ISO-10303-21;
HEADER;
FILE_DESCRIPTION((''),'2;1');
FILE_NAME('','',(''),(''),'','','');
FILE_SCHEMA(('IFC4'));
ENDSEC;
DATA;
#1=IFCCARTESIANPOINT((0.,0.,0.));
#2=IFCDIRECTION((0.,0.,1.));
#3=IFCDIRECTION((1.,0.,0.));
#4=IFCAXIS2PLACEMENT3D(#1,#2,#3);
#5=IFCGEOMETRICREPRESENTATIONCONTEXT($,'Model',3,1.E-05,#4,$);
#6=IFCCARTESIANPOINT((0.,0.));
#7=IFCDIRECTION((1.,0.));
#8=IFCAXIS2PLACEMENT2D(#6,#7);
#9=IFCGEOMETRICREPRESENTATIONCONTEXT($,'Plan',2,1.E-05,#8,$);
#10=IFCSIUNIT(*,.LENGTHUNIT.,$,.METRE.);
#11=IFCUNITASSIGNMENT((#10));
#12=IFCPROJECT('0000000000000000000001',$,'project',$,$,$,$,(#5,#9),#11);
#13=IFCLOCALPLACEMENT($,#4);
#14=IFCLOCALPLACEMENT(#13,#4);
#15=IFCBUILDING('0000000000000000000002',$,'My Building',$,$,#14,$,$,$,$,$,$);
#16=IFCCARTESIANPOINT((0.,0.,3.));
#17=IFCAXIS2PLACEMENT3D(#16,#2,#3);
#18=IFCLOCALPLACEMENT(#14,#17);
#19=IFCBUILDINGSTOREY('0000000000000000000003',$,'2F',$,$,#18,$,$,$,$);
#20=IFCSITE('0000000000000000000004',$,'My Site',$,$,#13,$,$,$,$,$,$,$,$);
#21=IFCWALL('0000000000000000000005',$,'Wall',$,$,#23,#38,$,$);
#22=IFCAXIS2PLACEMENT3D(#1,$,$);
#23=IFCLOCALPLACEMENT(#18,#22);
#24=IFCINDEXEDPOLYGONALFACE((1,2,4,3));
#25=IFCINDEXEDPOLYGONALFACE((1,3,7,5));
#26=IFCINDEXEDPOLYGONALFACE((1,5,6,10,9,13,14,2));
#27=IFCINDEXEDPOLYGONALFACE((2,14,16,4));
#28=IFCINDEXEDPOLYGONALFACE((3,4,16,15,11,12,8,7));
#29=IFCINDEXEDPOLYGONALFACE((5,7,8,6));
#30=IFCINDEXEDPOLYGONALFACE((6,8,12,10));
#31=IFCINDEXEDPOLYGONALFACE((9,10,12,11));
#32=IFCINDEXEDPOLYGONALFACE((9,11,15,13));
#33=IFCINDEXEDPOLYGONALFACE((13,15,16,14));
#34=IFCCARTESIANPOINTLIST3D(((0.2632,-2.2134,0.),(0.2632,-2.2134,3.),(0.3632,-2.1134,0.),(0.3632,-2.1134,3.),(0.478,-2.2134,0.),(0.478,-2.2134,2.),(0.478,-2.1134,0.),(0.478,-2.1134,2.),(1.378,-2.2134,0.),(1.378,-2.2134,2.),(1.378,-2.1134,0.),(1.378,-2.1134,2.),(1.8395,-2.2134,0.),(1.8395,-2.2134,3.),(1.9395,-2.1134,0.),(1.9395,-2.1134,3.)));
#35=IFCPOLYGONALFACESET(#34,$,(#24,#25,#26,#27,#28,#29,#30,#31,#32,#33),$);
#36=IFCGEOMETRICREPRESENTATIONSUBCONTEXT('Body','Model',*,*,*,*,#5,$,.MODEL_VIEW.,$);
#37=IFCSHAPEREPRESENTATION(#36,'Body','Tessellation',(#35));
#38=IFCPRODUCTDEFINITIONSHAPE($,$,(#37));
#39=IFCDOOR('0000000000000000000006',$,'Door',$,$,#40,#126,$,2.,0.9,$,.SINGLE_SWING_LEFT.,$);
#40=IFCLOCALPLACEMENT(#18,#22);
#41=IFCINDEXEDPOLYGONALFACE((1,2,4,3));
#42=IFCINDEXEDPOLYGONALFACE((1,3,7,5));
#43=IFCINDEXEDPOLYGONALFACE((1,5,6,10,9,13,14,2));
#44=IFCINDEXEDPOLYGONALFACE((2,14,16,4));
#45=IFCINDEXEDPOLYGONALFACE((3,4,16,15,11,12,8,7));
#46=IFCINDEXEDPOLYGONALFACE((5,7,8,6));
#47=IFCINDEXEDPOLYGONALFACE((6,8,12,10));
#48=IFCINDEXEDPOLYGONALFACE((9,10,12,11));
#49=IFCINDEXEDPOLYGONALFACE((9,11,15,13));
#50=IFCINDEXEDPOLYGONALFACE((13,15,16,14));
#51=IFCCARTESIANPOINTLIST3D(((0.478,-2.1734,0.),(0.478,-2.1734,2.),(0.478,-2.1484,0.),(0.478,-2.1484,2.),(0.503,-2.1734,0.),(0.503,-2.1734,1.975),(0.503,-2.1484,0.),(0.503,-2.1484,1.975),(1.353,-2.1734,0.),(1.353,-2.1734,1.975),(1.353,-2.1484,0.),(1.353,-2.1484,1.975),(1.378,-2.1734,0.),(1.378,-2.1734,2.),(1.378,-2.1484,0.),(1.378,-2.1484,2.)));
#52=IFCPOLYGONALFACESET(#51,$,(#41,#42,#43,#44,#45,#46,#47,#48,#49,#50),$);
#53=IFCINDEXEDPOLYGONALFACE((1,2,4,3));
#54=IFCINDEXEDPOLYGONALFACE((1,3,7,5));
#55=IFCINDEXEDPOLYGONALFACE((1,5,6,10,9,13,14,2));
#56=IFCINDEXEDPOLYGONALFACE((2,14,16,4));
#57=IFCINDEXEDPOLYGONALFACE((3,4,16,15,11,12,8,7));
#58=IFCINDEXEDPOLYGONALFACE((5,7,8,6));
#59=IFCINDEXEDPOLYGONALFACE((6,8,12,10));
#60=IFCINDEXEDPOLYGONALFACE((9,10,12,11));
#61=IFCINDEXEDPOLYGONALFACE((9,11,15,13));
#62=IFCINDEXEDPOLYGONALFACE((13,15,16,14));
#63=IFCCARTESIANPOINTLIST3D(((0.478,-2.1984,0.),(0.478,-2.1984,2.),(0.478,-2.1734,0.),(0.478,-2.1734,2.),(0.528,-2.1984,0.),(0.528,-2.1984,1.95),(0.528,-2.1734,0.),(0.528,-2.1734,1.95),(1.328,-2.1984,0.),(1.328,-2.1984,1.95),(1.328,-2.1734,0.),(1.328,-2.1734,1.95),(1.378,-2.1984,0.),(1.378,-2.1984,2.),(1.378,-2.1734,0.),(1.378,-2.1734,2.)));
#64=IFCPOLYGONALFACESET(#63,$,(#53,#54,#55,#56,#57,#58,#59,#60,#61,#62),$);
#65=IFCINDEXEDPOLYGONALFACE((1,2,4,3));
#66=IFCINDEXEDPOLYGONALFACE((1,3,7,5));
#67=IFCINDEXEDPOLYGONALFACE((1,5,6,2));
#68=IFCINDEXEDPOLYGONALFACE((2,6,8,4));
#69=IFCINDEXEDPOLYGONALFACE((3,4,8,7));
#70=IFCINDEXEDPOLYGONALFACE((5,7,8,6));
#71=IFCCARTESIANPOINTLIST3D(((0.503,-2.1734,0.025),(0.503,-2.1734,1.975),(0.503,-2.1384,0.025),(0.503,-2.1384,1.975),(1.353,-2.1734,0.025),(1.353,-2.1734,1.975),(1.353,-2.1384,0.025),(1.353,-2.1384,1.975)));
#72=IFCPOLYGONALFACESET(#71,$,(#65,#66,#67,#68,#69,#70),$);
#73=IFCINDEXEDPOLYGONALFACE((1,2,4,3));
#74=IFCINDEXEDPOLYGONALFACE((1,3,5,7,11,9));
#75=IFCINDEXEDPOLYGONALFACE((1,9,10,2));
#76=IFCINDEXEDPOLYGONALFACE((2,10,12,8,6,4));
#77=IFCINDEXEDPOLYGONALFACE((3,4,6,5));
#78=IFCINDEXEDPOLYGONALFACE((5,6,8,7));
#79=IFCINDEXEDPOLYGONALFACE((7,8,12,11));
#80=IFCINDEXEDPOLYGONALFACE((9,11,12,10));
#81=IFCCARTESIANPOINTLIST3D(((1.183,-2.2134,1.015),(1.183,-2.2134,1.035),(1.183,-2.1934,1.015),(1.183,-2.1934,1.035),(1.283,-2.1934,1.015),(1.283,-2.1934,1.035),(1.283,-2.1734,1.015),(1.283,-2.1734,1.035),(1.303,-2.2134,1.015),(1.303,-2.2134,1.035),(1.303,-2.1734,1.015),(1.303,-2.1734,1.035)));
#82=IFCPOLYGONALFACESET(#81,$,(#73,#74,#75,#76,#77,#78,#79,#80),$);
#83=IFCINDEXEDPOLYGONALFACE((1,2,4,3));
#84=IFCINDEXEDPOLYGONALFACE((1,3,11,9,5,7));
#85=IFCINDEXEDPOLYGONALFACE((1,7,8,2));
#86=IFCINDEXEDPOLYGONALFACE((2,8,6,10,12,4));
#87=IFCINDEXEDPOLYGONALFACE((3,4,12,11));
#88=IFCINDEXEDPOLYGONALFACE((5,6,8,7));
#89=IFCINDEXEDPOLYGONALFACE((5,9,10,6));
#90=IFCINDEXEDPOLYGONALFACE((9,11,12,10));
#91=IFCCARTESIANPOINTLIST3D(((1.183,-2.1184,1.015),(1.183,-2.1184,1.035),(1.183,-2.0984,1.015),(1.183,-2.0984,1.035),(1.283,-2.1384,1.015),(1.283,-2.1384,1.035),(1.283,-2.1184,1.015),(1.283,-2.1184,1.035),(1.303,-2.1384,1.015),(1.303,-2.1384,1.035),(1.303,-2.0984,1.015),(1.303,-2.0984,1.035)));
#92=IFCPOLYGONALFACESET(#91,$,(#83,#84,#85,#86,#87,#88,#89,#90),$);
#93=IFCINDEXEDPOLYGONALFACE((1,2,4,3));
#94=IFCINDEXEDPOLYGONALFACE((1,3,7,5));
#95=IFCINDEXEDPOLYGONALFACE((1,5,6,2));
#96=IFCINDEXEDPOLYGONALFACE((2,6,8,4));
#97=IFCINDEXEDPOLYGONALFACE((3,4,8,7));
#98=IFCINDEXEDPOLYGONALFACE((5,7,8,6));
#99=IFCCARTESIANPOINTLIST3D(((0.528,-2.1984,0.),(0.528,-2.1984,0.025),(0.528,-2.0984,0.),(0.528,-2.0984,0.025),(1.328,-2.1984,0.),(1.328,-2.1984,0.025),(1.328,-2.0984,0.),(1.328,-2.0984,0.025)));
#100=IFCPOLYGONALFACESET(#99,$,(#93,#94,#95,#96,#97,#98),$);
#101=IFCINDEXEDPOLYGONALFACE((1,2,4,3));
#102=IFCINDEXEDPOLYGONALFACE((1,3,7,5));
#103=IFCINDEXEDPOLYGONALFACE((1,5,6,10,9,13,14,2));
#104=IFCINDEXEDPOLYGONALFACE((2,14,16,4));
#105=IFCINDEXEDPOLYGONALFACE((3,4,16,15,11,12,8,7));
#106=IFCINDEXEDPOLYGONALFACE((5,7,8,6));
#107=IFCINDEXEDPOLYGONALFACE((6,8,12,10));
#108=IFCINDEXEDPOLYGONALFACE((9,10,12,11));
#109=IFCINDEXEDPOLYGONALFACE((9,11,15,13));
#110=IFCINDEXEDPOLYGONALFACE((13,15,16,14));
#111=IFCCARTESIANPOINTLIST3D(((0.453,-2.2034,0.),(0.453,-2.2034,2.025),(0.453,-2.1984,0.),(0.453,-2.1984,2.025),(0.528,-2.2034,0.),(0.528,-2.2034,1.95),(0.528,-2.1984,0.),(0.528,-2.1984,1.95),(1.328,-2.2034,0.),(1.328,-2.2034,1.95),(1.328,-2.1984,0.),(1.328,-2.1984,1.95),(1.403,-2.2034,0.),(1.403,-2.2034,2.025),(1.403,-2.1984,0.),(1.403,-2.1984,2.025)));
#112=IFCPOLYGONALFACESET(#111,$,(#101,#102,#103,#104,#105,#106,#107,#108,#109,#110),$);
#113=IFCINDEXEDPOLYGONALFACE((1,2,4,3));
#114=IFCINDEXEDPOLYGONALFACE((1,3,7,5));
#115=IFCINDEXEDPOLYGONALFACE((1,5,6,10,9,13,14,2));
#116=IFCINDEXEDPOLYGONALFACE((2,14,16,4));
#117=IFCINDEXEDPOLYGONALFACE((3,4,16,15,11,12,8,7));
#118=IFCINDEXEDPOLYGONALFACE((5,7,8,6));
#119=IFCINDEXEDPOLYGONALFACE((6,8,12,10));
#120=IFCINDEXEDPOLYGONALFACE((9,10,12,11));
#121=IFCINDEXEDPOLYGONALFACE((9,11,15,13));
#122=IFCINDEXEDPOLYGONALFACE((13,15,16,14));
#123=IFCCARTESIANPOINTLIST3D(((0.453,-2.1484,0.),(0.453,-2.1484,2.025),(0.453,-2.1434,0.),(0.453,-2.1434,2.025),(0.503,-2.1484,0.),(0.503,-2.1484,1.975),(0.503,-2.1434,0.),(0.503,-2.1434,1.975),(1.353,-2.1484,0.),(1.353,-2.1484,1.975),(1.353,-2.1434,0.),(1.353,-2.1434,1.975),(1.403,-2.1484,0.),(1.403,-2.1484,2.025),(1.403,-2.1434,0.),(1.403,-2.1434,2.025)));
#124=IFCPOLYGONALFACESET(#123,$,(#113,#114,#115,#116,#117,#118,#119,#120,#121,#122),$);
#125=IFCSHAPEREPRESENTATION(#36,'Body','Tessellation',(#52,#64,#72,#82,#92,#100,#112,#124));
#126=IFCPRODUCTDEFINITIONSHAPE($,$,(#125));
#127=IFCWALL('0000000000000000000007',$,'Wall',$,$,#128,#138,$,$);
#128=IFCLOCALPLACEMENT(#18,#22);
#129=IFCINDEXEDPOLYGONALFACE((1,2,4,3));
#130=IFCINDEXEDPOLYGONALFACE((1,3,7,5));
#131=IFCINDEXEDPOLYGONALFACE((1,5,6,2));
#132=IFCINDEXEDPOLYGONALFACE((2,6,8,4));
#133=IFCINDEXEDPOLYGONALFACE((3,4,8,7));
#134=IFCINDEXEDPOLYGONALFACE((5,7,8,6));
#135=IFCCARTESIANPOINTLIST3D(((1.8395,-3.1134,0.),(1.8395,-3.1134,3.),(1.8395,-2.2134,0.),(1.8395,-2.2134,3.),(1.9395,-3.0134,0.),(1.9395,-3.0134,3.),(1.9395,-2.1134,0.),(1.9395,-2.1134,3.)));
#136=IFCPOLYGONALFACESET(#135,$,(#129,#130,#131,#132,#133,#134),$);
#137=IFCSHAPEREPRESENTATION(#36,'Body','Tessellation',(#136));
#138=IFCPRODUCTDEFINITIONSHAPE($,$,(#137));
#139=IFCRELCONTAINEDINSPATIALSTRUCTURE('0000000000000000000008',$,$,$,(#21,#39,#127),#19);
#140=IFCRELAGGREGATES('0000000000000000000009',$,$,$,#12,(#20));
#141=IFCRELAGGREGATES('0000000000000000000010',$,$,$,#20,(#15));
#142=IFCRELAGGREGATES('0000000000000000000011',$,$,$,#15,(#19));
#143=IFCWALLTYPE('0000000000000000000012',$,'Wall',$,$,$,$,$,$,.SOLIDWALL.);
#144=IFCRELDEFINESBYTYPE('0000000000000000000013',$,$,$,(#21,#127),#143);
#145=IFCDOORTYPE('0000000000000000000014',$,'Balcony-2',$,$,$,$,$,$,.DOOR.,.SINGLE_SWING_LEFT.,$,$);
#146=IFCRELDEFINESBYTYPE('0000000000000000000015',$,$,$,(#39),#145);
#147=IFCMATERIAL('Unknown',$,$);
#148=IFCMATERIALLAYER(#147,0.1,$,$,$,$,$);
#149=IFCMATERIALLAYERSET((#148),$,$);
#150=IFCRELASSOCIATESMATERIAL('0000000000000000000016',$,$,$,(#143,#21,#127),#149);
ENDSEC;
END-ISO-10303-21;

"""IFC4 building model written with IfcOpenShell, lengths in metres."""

from ifc_helpers import new_model, entity, si_unit, frame, origin_with_axes, origin_2d_with_axis, place, context, subcontext, project, spatial, line, indexed_curve, outline, extrude, shape, source, transform, mapped, material, layer, layer_set, layer_usage, type_object, type_shapes, element, fill, save


model = new_model("IFC4")

# Units and contexts
model_context_1 = context("Model", 3, precision=1e-05, world=origin_with_axes())
plan_context = context("Plan", 2, precision=1e-05, world=origin_2d_with_axis())
body_context_1 = subcontext(model_context_1, "Body", "Model", "MODEL_VIEW")
body_context_2 = subcontext(plan_context, "Body", "Plan", "PLAN_VIEW")
ifc_project = project(units=[si_unit("LENGTHUNIT", "METRE")], contexts=[model_context_1, plan_context])

# Site, building, storey
site_placement = place(None, origin_with_axes())
site = spatial("IfcSite", under=ifc_project, at=site_placement, Name="My Site")
building_placement = place(site_placement, origin_with_axes())
building = spatial("IfcBuilding", under=site, at=building_placement, Name="My Building")
storey_placement = place(building_placement, frame((0.0, 0.0, 3.0), z_axis=(0.0, 0.0, 1.0), x_axis=(1.0, 0.0, 0.0)))
storey = spatial("IfcBuildingStorey", under=building, at=storey_placement, Name="2F")

# Shared definitions
ifc_material = material(Name="Unknown")

# Shared definitions
ifc_layer_1 = layer(ifc_material, 0.1)
ifc_layer_set_1 = layer_set([ifc_layer_1])
wall_type = type_object("IfcWallType", Name="Wall", PredefinedType="SOLIDWALL", material=ifc_layer_set_1)

# Wall, opening, door
ifc_layer_usage_1 = layer_usage(ifc_layer_set_1, "AXIS2", "POSITIVE", 0.0)
wall_1_placement = place(storey_placement, frame((0.2632, -2.2134, 0.0), z_axis=(0.0, 0.0, 1.0), x_axis=(1.0, 0.0, 0.0)))
wall_1 = element("IfcWall", 1, at=wall_1_placement, inside=storey, type_object=wall_type, material=ifc_layer_usage_1, Name="Wall", context=body_context_1, shape_type="SweptSolid", body=[
    extrude(outline(indexed_curve([(0.0, 0.0), (0.1, 0.1), (1.6764, 0.1), (1.5764, 0.0)], segments=[line(1, 2, 3, 4, 1)])), origin_with_axes(), (0.0, 0.0, 1.0), 3.0),
])
shared_shape_1 = source(origin_with_axes(), body_context_1, "Body", "SweptSolid", [
    extrude(outline(indexed_curve([(0.0, 0.0), (0.9, 0.0), (0.9, 2.0), (0.0, 2.0)], segments=[line(1, 2, 3, 4, 1)])), frame((0.0, -0.6, 0.0), z_axis=(0.0, -1.0, 0.0), x_axis=(1.0, 0.0, 0.0)), (0.0, 0.0, -1.0), 1.2),
])
opening_1_placement = place(wall_1_placement, frame((0.2148, 0.015, 0.0), z_axis=(0.0, 0.0, 1.0), x_axis=(1.0, 0.0, 0.0)))
opening_1 = element("IfcOpeningElement", 2, at=opening_1_placement, cuts=wall_1, PredefinedType="OPENING", context=body_context_1, shape_type="MappedRepresentation", body=[
    mapped(shared_shape_1, transform((0.0, 0.0, 0.0), x_axis=(1.0, 0.0, 0.0), y_axis=(0.0, 1.0, 0.0), z_axis=(0.0, 0.0, 1.0), scale=1.0)),
])
door_type_1 = type_object("IfcDoorType", Name="Balcony-2", OperationType="SINGLE_SWING_LEFT", PredefinedType="DOOR")
shared_shape_2 = source(origin_with_axes(), body_context_1, "Body", "SweptSolid", [
    extrude(outline(indexed_curve([(0.0, 0.0), (0.0, 2.0), (0.9, 2.0), (0.9, 0.0), (0.875, 0.0), (0.875, 1.975), (0.025, 1.975), (0.025, 0.0)], segments=[line(1, 2, 3, 4, 5, 6, 7, 8, 1)])), frame((0.0, 0.025, 0.0), z_axis=(0.0, -1.0, 0.0), x_axis=(1.0, 0.0, 0.0)), (0.0, 0.0, -1.0), 0.025),
    extrude(outline(indexed_curve([(0.0, 0.0), (0.0, 2.0), (0.9, 2.0), (0.9, 0.0), (0.85, 0.0), (0.85, 1.95), (0.05, 1.95), (0.05, 0.0)], segments=[line(1, 2, 3, 4, 5, 6, 7, 8, 1)])), frame((0.0, 0.0, 0.0), z_axis=(0.0, -1.0, 0.0), x_axis=(1.0, 0.0, 0.0)), (0.0, 0.0, -1.0), 0.025),
    extrude(outline(indexed_curve([(0.0, 0.0), (0.85, 0.0), (0.85, 0.035), (0.0, 0.035)], segments=[line(1, 2, 3, 4, 1)])), frame((0.025, 0.025, 0.025), z_axis=(0.0, 0.0, 1.0), x_axis=(1.0, 0.0, 0.0)), (0.0, 0.0, 1.0), 1.95),
    extrude(outline(indexed_curve([(0.0, 0.0), (0.0, -0.04), (-0.12, -0.04), (-0.12, -0.02), (-0.02, -0.02), (-0.02, 0.0)], segments=[line(1, 2, 3, 4, 5, 6, 1)])), frame((0.825, 0.025, 1.015), z_axis=(0.0, 0.0, 1.0), x_axis=(1.0, 0.0, 0.0)), (0.0, 0.0, 1.0), 0.02),
    extrude(outline(indexed_curve([(0.0, 0.0), (0.0, 0.04), (-0.12, 0.04), (-0.12, 0.02), (-0.02, 0.02), (-0.02, 0.0)], segments=[line(1, 2, 3, 4, 5, 6, 1)])), frame((0.825, 0.06, 1.015), z_axis=(0.0, 0.0, 1.0), x_axis=(1.0, 0.0, 0.0)), (0.0, 0.0, 1.0), 0.02),
    extrude(outline(indexed_curve([(0.0, 0.0), (0.8, 0.0), (0.8, 0.1), (0.0, 0.1)], segments=[line(1, 2, 3, 4, 1)])), frame((0.05, 0.0, 0.0), z_axis=(0.0, 0.0, 1.0), x_axis=(1.0, 0.0, 0.0)), (0.0, 0.0, 1.0), 0.025),
    extrude(outline(indexed_curve([(0.0, 0.0), (0.0, 2.025), (0.95, 2.025), (0.95, 0.0), (0.875, 0.0), (0.875, 1.95), (0.075, 1.95), (0.075, 0.0)], segments=[line(1, 2, 3, 4, 5, 6, 7, 8, 1)])), frame((-0.025, -0.005, 0.0), z_axis=(0.0, -1.0, 0.0), x_axis=(1.0, 0.0, 0.0)), (0.0, 0.0, -1.0), 0.005),
    extrude(outline(indexed_curve([(0.0, 0.0), (0.0, 2.025), (0.95, 2.025), (0.95, 0.0), (0.9, 0.0), (0.9, 1.975), (0.05, 1.975), (0.05, 0.0)], segments=[line(1, 2, 3, 4, 5, 6, 7, 8, 1)])), frame((-0.025, 0.05, 0.0), z_axis=(0.0, -1.0, 0.0), x_axis=(1.0, 0.0, 0.0)), (0.0, 0.0, -1.0), 0.005),
])
shared_shape_3 = source(origin_with_axes(), body_context_2, "Body", "Curve2D", [
    entity("IfcIndexedPolyCurve", entity("IfcCartesianPointList2D", [[0.0, 0.0], [0.0, 0.05], [0.025, 0.05], [0.025, 0.025], [0.05, 0.025], [0.05, 0.0]]), [entity("IfcLineIndex", [1, 2, 3, 4, 5, 6, 1])]),
    entity("IfcIndexedPolyCurve", entity("IfcCartesianPointList2D", [[0.9, 0.0], [0.9, 0.05], [0.875, 0.05], [0.875, 0.025], [0.85, 0.025], [0.85, 0.0]]), [entity("IfcLineIndex", [1, 2, 3, 4, 5, 6, 1])]),
    entity("IfcTrimmedCurve", entity("IfcEllipse", entity("IfcAxis2Placement2D", entity("IfcCartesianPoint", [0.06, 0.05]), entity("IfcDirection", [1.0, 0.0])), 0.815, 0.85), [entity("IfcCartesianPoint", [0.875, 0.05])], [entity("IfcCartesianPoint", [0.06, 0.9])], True, "CARTESIAN"),
    entity("IfcIndexedPolyCurve", entity("IfcCartesianPointList2D", [[0.025, 0.05], [0.06, 0.05], [0.06, 0.9], [0.025, 0.9]]), [entity("IfcLineIndex", [1, 2, 3, 4, 1])]),
])
type_shapes(door_type_1, [shared_shape_2, shared_shape_3])
door_1_placement = place(opening_1_placement, frame((0.0, 0.0, 0.0), z_axis=(0.0, 0.0, 1.0), x_axis=(1.0, 0.0, 0.0)))
door_1 = element("IfcDoor", 3, at=door_1_placement, inside=storey, type_object=door_type_1, Name="Door", OperationType="SINGLE_SWING_LEFT", OverallHeight=2.0, OverallWidth=0.9, shapes=[
    shape(body_context_1, "Body", "MappedRepresentation", [mapped(shared_shape_2, transform((0.0, 0.0, 0.0), x_axis=(1.0, 0.0, 0.0), y_axis=(0.0, 1.0, 0.0), z_axis=(0.0, 0.0, 1.0), scale=1.0))]),
    shape(body_context_2, "Body", "MappedRepresentation", [mapped(shared_shape_3, transform((0.0, 0.0, 0.0), x_axis=(1.0, 0.0, 0.0), y_axis=(0.0, 1.0, 0.0), z_axis=(0.0, 0.0, 1.0), scale=1.0))]),
])
fill(opening_1, door_1)

# Wall
ifc_layer_usage_2 = layer_usage(ifc_layer_set_1, "AXIS2", "POSITIVE", 0.0)
wall_2_placement = place(storey_placement, frame((1.8395, -2.2134, 0.0), z_axis=(0.0, 0.0, 1.0), x_axis=(0.0, -1.0, 0.0)))
element("IfcWall", 4, at=wall_2_placement, inside=storey, type_object=wall_type, material=ifc_layer_usage_2, Name="Wall", context=body_context_1, shape_type="SweptSolid", body=[
    extrude(outline(indexed_curve([(0.0, 0.0), (-0.1, 0.1), (0.8, 0.1), (0.9, 0.0)], segments=[line(1, 2, 3, 4, 1)])), origin_with_axes(), (0.0, 0.0, 1.0), 3.0),
])

save(model, "model.ifc")
